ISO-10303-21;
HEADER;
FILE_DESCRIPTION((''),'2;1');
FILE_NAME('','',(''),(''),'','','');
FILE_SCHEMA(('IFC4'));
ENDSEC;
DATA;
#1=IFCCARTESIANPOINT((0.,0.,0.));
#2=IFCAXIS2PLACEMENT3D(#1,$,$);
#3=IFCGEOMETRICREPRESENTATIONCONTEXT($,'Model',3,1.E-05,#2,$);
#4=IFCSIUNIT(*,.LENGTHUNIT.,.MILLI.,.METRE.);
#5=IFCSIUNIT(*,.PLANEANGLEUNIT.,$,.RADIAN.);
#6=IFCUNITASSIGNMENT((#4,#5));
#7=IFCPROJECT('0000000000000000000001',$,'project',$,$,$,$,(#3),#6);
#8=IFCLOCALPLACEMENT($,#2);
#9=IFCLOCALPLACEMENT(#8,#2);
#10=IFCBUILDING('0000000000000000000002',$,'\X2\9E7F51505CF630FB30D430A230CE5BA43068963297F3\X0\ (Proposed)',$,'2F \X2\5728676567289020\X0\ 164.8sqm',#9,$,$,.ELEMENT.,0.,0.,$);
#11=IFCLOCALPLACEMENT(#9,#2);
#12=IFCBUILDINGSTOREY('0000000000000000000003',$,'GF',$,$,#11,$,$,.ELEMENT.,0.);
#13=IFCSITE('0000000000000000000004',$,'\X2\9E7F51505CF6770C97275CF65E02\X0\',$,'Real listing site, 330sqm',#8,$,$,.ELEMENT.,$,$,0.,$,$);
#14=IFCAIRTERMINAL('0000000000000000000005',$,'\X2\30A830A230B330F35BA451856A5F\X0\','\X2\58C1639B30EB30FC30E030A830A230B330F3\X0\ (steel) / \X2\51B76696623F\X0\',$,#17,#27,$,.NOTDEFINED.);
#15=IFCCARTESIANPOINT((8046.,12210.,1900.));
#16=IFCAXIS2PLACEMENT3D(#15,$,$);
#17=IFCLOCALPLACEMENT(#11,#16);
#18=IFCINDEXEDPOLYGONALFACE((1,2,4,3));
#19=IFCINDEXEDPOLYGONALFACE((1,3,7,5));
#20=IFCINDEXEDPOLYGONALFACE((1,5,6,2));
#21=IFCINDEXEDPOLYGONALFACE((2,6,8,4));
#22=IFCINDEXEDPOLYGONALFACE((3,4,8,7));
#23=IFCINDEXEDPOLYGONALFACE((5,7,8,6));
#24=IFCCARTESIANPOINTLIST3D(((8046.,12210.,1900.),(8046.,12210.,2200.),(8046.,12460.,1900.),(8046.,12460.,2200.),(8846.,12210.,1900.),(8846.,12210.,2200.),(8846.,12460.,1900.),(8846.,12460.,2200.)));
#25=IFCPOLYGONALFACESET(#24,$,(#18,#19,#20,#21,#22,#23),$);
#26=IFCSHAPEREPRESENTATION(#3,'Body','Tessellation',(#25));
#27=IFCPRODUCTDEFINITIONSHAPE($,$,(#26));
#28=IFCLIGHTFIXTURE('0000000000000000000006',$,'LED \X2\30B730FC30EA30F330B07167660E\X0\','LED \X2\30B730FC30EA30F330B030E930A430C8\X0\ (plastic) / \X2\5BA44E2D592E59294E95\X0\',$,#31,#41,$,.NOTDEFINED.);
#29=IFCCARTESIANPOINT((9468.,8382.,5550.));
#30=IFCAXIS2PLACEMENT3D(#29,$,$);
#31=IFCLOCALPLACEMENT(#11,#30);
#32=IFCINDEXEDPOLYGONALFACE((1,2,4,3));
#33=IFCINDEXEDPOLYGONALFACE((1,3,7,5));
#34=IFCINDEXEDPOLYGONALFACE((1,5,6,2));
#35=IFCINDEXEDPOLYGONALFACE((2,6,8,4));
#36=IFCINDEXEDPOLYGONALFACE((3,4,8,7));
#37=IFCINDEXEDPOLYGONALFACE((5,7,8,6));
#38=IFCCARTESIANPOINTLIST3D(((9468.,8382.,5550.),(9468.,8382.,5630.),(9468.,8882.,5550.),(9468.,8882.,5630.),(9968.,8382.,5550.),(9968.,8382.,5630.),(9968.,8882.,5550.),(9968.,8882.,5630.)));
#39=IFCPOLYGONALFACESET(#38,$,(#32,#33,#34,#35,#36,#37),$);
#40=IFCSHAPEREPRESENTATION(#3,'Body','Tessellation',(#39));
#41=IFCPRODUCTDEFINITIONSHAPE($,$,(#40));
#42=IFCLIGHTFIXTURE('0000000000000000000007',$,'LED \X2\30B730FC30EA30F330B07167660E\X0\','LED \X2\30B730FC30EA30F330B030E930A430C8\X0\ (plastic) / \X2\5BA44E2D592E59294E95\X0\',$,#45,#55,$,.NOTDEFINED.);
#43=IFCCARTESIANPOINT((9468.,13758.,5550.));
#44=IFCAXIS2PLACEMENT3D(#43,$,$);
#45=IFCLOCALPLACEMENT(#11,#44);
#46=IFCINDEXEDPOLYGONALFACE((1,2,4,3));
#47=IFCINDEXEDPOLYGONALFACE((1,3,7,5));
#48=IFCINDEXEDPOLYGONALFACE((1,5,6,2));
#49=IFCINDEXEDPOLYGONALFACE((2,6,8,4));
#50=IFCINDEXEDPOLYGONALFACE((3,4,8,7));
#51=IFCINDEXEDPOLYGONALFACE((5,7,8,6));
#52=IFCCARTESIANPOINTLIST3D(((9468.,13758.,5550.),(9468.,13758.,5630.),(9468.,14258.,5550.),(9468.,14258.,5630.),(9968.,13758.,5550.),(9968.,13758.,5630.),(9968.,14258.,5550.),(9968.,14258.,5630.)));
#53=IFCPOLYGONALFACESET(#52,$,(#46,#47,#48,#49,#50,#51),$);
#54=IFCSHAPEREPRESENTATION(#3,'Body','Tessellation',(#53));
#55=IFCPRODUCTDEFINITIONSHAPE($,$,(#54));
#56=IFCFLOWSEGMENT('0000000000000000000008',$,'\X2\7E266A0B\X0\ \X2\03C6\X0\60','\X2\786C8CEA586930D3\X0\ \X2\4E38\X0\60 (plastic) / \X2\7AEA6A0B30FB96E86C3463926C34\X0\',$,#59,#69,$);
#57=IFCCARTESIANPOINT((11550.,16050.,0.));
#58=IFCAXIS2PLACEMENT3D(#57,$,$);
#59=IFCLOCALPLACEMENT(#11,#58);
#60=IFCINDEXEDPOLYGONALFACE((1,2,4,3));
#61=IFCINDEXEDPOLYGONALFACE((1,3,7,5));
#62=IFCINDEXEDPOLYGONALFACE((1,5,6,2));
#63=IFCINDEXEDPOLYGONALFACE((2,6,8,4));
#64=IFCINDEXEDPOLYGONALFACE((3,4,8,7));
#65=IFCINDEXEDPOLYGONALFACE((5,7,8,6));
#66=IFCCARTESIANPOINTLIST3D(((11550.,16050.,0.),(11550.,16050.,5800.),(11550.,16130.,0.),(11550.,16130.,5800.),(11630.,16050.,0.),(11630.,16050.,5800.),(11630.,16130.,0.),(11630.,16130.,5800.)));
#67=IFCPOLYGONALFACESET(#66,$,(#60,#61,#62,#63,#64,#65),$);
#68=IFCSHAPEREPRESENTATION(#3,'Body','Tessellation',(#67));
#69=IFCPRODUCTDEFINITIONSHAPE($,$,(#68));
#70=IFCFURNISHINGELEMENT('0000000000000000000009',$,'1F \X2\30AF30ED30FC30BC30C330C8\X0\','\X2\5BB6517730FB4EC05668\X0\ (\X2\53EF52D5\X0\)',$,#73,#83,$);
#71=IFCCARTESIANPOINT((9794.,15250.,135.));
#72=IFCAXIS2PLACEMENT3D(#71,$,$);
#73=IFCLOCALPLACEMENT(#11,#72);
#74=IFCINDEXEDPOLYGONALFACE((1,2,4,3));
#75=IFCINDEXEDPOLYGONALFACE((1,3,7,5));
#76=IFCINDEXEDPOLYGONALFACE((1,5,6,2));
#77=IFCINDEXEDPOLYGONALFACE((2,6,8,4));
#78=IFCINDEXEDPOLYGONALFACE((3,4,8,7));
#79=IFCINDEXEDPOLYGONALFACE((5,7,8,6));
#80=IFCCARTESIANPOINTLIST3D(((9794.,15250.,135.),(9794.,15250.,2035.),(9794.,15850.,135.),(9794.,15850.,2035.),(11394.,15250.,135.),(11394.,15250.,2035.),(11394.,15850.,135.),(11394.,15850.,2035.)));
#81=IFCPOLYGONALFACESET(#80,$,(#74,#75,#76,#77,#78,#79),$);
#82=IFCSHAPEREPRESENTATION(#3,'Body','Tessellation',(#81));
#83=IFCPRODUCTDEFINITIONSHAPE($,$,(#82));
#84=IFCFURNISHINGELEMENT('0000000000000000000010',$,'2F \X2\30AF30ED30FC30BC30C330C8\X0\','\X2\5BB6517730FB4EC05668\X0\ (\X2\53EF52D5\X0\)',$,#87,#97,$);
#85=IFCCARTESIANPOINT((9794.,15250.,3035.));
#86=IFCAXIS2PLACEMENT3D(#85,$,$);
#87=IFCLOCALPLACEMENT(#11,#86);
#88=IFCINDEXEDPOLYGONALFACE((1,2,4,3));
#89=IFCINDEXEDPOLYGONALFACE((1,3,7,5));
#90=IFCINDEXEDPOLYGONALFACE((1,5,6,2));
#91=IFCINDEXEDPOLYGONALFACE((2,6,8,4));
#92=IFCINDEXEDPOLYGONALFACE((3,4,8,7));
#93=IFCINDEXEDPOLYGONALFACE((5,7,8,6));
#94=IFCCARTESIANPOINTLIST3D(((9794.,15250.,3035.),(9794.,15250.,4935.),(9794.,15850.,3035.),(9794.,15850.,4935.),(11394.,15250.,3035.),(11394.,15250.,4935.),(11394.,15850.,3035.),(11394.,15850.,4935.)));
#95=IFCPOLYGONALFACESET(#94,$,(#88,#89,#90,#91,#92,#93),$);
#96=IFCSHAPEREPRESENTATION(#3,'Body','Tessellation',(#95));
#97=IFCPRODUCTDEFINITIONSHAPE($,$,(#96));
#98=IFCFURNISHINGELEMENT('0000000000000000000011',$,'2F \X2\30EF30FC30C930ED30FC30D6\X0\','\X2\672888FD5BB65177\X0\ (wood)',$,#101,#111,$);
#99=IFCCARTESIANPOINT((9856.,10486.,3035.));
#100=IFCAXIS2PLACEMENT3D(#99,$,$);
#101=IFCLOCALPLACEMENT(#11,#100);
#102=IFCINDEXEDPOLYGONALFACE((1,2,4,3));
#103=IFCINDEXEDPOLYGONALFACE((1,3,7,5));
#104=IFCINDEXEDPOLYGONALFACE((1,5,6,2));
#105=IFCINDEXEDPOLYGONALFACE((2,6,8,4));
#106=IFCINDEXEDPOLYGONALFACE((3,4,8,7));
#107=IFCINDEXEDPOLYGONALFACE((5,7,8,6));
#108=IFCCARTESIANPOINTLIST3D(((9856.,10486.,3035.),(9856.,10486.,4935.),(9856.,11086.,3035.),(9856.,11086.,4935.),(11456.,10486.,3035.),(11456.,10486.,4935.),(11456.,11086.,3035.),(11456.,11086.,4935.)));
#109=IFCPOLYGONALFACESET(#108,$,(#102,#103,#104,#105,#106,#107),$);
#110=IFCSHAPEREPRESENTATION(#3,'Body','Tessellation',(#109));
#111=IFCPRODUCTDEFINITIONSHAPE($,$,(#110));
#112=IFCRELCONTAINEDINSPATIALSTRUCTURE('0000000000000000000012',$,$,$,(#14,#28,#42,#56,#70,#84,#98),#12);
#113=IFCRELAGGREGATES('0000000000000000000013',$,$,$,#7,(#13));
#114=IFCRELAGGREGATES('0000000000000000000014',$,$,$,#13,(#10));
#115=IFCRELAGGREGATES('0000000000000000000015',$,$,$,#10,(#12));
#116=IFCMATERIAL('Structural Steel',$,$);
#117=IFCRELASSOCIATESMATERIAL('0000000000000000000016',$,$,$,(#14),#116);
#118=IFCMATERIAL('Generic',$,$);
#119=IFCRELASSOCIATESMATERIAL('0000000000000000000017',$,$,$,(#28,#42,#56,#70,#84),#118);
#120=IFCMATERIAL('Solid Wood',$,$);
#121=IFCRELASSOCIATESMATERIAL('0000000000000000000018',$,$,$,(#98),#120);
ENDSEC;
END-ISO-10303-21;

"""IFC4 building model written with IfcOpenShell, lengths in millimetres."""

from ifc_helpers import new_model, si_unit, frame, frame_2d, origin, place, context, project, spatial, rectangle, extrude, material, element, save


model = new_model("IFC4")

# Units and contexts
model_context = context("Model", 3, precision=1e-05, world=origin())
ifc_project = project(units=[si_unit("LENGTHUNIT", "METRE", prefix="MILLI"), si_unit("PLANEANGLEUNIT", "RADIAN")], contexts=[model_context])

# Site, building, storey
site_placement = place(None, origin())
site = spatial("IfcSite", under=ifc_project, at=site_placement, Name="鹿児島県霧島市", ObjectType="Real listing site, 330sqm", CompositionType="ELEMENT", RefElevation=0.0)
building_placement = place(site_placement, origin())
building = spatial("IfcBuilding", under=site, at=building_placement, Name="鹿児島・ピアノ室と防音 (Proposed)", ObjectType="2F 在来木造 164.8sqm", CompositionType="ELEMENT", ElevationOfRefHeight=0.0, ElevationOfTerrain=0.0)
storey_placement = place(building_placement, origin())
storey = spatial("IfcBuildingStorey", under=building, at=storey_placement, Name="GF", CompositionType="ELEMENT", Elevation=0.0)

# Shared definitions
ifc_material_1 = material(Name="Solid Wood")

# Shared definitions
ifc_material_2 = material(Name="Generic")

# Shared definitions
ifc_material_3 = material(Name="Structural Steel")

# Air terminal
air_terminal_placement = place(storey_placement, frame((8046.0, 12210.0, 1900.0)))
element("IfcAirTerminal", 1, at=air_terminal_placement, inside=storey, material=ifc_material_3, Name="エアコン室内機", Description="壁掛ルームエアコン (steel) / 冷暖房", PredefinedType="NOTDEFINED", context=model_context, shape_type="SweptSolid", body=[
    extrude(rectangle(XDim=800.0, YDim=250.0, at=frame_2d((400.0, 125.0))), frame((8046.0, 12210.0, 1900.0)), (0.0, 0.0, 1.0), 300.0),
])

# Light fixtures
light_fixture_1_placement = place(storey_placement, frame((9468.0, 8382.0, 5550.0)))
element("IfcLightFixture", 2, at=light_fixture_1_placement, inside=storey, material=ifc_material_2, Name="LED シーリング照明", Description="LED シーリングライト (plastic) / 室中央天井", PredefinedType="NOTDEFINED", context=model_context, shape_type="SweptSolid", body=[
    extrude(rectangle(XDim=500.0, YDim=500.0, at=frame_2d((250.0, 250.0))), frame((9468.0, 8382.0, 5550.0)), (0.0, 0.0, 1.0), 80.0),
])
light_fixture_2_placement = place(storey_placement, frame((9468.0, 13758.0, 5550.0)))
element("IfcLightFixture", 3, at=light_fixture_2_placement, inside=storey, material=ifc_material_2, Name="LED シーリング照明", Description="LED シーリングライト (plastic) / 室中央天井", PredefinedType="NOTDEFINED", context=model_context, shape_type="SweptSolid", body=[
    extrude(rectangle(XDim=500.0, YDim=500.0, at=frame_2d((250.0, 250.0))), frame((9468.0, 13758.0, 5550.0)), (0.0, 0.0, 1.0), 80.0),
])

# Flow segment
flow_segment_placement = place(storey_placement, frame((11550.0, 16050.0, 0.0)))
element("IfcFlowSegment", 4, at=flow_segment_placement, inside=storey, material=ifc_material_2, Name="縦樋 φ60", Description="硬質塩ビ 丸60 (plastic) / 竪樋・雨水排水", context=model_context, shape_type="SweptSolid", body=[
    extrude(rectangle(XDim=80.0, YDim=80.0, at=frame_2d((40.0, 40.0))), frame((11550.0, 16050.0, 0.0)), (0.0, 0.0, 1.0), 5800.0),
])

# Furnishing elements
furnishing_1_placement = place(storey_placement, frame((9794.0, 15250.0, 135.0)))
element("IfcFurnishingElement", 5, at=furnishing_1_placement, inside=storey, material=ifc_material_2, Name="1F クローゼット", Description="家具・什器 (可動)", context=model_context, shape_type="SweptSolid", body=[
    extrude(rectangle(XDim=1600.0, YDim=600.0, at=frame_2d((800.0, 300.0))), frame((9794.0, 15250.0, 135.0)), (0.0, 0.0, 1.0), 1900.0),
])
furnishing_2_placement = place(storey_placement, frame((9794.0, 15250.0, 3035.0)))
element("IfcFurnishingElement", 6, at=furnishing_2_placement, inside=storey, material=ifc_material_2, Name="2F クローゼット", Description="家具・什器 (可動)", context=model_context, shape_type="SweptSolid", body=[
    extrude(rectangle(XDim=1600.0, YDim=600.0, at=frame_2d((800.0, 300.0))), frame((9794.0, 15250.0, 3035.0)), (0.0, 0.0, 1.0), 1900.0),
])
furnishing_3_placement = place(storey_placement, frame((9856.0, 10486.0, 3035.0)))
element("IfcFurnishingElement", 7, at=furnishing_3_placement, inside=storey, material=ifc_material_1, Name="2F ワードローブ", Description="木製家具 (wood)", context=model_context, shape_type="SweptSolid", body=[
    extrude(rectangle(XDim=1600.0, YDim=600.0, at=frame_2d((800.0, 300.0))), frame((9856.0, 10486.0, 3035.0)), (0.0, 0.0, 1.0), 1900.0),
])

save(model, "model.ifc")
